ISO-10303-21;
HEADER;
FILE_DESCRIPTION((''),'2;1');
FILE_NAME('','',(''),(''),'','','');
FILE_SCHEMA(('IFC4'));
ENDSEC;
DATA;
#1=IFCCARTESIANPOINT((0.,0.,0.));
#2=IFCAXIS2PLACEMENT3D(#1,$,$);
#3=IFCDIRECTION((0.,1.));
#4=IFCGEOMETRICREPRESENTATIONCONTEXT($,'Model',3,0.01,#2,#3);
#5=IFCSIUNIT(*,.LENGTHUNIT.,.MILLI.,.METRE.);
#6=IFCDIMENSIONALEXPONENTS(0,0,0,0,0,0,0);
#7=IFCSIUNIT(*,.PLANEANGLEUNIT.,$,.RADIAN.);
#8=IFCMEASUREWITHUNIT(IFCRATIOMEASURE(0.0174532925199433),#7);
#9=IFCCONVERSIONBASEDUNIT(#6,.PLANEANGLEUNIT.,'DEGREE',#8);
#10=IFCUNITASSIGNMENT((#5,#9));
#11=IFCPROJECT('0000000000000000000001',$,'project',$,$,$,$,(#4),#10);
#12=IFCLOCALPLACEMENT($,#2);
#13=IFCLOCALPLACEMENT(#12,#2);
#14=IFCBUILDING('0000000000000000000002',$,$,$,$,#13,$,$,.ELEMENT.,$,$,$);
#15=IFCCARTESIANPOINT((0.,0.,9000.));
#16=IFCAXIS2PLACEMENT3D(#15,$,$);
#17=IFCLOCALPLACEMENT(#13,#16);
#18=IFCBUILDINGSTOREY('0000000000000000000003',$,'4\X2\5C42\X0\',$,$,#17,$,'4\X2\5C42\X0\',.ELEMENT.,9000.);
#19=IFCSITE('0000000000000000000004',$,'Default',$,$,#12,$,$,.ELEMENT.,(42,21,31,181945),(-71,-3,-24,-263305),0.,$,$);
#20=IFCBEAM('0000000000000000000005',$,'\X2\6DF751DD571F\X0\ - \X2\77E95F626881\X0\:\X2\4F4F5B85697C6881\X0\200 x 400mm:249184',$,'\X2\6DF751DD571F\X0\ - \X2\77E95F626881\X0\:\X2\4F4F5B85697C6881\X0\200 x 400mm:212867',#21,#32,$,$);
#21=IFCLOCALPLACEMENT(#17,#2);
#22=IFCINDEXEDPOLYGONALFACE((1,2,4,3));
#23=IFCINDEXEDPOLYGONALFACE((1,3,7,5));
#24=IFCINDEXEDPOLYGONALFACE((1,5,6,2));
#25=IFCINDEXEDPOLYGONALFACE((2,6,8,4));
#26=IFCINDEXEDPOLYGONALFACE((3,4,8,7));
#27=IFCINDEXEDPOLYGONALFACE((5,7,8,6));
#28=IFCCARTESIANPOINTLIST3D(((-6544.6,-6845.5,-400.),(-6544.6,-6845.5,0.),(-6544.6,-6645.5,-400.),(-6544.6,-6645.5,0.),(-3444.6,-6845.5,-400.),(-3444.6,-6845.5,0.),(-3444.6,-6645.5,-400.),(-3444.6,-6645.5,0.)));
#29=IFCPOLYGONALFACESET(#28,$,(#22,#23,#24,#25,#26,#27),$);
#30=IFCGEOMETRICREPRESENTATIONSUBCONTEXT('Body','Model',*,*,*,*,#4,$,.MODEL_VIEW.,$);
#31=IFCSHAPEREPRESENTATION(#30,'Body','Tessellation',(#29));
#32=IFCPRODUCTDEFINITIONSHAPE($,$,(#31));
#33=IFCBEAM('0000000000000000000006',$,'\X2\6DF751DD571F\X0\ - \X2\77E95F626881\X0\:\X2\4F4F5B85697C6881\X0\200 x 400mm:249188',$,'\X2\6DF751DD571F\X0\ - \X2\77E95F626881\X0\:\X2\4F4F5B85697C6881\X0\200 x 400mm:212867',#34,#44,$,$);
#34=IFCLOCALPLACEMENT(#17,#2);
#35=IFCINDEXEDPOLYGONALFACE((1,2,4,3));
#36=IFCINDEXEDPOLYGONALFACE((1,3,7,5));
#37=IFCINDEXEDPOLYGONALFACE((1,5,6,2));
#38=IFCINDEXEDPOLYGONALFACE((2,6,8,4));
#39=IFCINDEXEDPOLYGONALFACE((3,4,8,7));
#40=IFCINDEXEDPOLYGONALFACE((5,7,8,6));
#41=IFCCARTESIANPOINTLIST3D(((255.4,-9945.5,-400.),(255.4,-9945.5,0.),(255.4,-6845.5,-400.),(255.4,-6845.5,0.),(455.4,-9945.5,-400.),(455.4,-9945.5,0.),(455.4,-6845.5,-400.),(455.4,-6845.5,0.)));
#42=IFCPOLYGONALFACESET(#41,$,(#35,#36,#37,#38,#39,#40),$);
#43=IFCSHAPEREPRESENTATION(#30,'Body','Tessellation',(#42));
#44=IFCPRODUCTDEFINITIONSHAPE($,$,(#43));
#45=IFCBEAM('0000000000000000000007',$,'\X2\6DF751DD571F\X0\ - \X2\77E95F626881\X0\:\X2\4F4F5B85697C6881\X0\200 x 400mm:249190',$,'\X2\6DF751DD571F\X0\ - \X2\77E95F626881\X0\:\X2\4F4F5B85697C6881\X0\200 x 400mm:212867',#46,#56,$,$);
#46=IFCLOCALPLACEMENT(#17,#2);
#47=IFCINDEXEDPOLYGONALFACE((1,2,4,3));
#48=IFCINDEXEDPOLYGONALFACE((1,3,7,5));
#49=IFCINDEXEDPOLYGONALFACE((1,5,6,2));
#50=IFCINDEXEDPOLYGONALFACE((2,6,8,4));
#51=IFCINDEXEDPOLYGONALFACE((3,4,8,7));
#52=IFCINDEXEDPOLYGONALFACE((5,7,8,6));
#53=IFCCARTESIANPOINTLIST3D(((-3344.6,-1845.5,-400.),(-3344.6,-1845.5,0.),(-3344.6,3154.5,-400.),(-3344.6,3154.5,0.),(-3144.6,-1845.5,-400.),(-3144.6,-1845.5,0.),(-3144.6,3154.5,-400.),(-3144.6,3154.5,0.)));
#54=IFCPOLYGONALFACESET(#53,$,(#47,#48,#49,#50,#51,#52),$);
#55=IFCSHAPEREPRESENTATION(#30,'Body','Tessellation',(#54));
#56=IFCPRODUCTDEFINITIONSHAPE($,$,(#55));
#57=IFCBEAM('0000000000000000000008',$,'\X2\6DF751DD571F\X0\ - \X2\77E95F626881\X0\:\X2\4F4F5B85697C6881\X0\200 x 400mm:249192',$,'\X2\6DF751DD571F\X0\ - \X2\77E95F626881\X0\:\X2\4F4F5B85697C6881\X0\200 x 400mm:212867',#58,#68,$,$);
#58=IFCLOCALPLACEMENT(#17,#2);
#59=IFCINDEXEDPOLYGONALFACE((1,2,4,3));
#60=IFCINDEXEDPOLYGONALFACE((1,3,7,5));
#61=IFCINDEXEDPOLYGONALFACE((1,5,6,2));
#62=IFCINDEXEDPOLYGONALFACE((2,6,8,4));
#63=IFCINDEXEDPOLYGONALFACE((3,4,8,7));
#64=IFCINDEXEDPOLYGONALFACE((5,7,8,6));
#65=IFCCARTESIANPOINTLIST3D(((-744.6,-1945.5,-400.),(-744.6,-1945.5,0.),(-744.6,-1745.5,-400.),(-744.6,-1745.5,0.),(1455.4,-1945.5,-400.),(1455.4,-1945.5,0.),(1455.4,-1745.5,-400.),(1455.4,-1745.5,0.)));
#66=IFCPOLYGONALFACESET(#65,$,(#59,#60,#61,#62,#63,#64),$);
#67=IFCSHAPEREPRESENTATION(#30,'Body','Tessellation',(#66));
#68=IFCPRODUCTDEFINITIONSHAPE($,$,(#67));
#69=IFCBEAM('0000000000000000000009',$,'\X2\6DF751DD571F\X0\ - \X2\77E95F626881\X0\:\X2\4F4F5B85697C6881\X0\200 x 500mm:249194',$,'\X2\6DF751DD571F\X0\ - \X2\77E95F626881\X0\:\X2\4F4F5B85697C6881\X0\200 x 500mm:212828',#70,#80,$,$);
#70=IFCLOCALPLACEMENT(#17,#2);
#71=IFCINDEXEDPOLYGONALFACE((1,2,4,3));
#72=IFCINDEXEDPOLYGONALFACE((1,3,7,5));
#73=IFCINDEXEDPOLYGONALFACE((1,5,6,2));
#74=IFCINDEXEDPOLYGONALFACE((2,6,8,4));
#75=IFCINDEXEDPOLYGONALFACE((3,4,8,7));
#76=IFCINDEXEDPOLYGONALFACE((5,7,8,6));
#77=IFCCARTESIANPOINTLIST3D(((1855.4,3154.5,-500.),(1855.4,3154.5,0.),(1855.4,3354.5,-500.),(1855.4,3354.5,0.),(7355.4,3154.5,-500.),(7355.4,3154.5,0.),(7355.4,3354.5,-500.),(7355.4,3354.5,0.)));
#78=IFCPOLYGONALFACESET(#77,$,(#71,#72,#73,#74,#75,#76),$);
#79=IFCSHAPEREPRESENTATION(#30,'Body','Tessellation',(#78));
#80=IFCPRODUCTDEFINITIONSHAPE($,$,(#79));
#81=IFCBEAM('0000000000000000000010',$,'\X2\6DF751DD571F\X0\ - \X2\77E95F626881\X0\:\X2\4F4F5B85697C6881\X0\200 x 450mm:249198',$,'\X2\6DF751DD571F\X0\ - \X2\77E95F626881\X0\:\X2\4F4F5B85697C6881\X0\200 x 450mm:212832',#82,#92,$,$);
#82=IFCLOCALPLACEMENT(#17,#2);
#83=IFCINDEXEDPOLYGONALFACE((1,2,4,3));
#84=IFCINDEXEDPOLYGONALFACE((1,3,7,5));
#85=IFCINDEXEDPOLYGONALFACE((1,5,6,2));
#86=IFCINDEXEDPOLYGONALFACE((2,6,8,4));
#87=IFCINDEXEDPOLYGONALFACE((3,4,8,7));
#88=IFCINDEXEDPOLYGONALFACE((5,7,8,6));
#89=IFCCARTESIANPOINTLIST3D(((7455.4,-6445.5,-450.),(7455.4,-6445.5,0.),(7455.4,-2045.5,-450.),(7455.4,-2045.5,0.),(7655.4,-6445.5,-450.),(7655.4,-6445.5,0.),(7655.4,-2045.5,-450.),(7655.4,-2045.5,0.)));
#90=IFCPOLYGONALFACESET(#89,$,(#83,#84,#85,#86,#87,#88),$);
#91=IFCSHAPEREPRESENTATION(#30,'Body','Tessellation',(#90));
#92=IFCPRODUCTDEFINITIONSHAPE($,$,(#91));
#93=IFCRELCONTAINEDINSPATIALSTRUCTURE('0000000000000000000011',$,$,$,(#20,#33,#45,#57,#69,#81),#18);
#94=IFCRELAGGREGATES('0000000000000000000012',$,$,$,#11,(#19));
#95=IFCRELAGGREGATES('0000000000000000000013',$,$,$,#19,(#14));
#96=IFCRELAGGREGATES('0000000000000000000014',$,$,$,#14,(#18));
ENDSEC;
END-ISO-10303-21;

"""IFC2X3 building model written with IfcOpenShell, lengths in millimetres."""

from ifc_helpers import new_model, entity, si_unit, converted_unit, direction, frame, frame_2d, origin, origin_2d_with_axis, place, context, subcontext, project, spatial, rectangle, extrude, element, save


model = new_model("IFC2X3")

# Units and contexts
model_context = context("Model", 3, precision=0.01, world=origin(), true_north=direction((0.0, 1.0)))
body_context = subcontext(model_context, "Body", "Model", "MODEL_VIEW")
ifc_project = project(units=[si_unit("LENGTHUNIT", "METRE", prefix="MILLI"), converted_unit("PLANEANGLEUNIT", "DEGREE", entity("IfcRatioMeasure", 0.0174532925199433), si_unit("PLANEANGLEUNIT", "RADIAN"), dimensions=[0, 0, 0, 0, 0, 0, 0])], contexts=[model_context])

# Site, building, storey
site_placement = place(None, origin())
site = spatial("IfcSite", under=ifc_project, at=site_placement, Name="Default", CompositionType="ELEMENT", RefLatitude=(42, 21, 31, 181945), RefLongitude=(-71, -3, -24, -263305), RefElevation=0.0)
building_placement = place(site_placement, origin())
building = spatial("IfcBuilding", under=site, at=building_placement, CompositionType="ELEMENT")
storey_placement = place(building_placement, frame((0.0, 0.0, 9000.0)))
storey = spatial("IfcBuildingStorey", under=building, at=storey_placement, Name="4层", LongName="4层", CompositionType="ELEMENT", Elevation=9000.0)

# Beams
beam_1_placement = place(storey_placement, frame((-3244.6, -6745.5, 0.0), z_axis=(0.0, 0.0, 1.0), x_axis=(-1.0, 0.0, 0.0)))
element("IfcBeam", 1, at=beam_1_placement, inside=storey, Name="混凝土 - 矩形梁:住宅楼梁200 x 400mm:249184", ObjectType="混凝土 - 矩形梁:住宅楼梁200 x 400mm:212867", context=body_context, shape_type="SweptSolid", body=[
    extrude(rectangle(XDim=400.0, YDim=200.0, at=frame_2d((0.0, 0.0), x_axis=(1.0, 0.0))), frame((200.0, 0.0, -200.0), z_axis=(1.0, 0.0, 0.0), x_axis=(0.0, 0.0, -1.0)), (0.0, 0.0, 1.0), 3100.0),
])
beam_2_placement = place(storey_placement, frame((355.4, -10145.5, 0.0), z_axis=(0.0, 0.0, 1.0), x_axis=(0.0, 1.0, 0.0)))
element("IfcBeam", 2, at=beam_2_placement, inside=storey, Name="混凝土 - 矩形梁:住宅楼梁200 x 400mm:249188", ObjectType="混凝土 - 矩形梁:住宅楼梁200 x 400mm:212867", context=body_context, shape_type="SweptSolid", body=[
    extrude(rectangle(XDim=400.0, YDim=200.0, at=frame_2d((0.0, 0.0), x_axis=(1.0, 0.0))), frame((200.0, 0.0, -200.0), z_axis=(1.0, 0.0, 0.0), x_axis=(0.0, 0.0, -1.0)), (0.0, 0.0, 1.0), 3100.0),
])
beam_3_placement = place(storey_placement, frame((-3244.6, 3254.5, 0.0), z_axis=(0.0, 0.0, 1.0), x_axis=(0.0, -1.0, 0.0)))
element("IfcBeam", 3, at=beam_3_placement, inside=storey, Name="混凝土 - 矩形梁:住宅楼梁200 x 400mm:249190", ObjectType="混凝土 - 矩形梁:住宅楼梁200 x 400mm:212867", context=body_context, shape_type="SweptSolid", body=[
    extrude(rectangle(XDim=400.0, YDim=200.0, at=origin_2d_with_axis()), frame((100.0, 0.0, -200.0), z_axis=(1.0, 0.0, 0.0), x_axis=(0.0, 0.0, -1.0)), (0.0, 0.0, 1.0), 5000.0),
])
beam_4_placement = place(storey_placement, frame((-944.6, -1845.5, 0.0)))
element("IfcBeam", 4, at=beam_4_placement, inside=storey, Name="混凝土 - 矩形梁:住宅楼梁200 x 400mm:249192", ObjectType="混凝土 - 矩形梁:住宅楼梁200 x 400mm:212867", context=body_context, shape_type="SweptSolid", body=[
    extrude(rectangle(XDim=400.0, YDim=200.0, at=frame_2d((0.0, 0.0), x_axis=(1.0, 0.0))), frame((200.0, 0.0, -200.0), z_axis=(1.0, 0.0, 0.0), x_axis=(0.0, 0.0, -1.0)), (0.0, 0.0, 1.0), 2200.0),
])
beam_5_placement = place(storey_placement, frame((7555.4, 3254.5, 0.0), z_axis=(0.0, 0.0, 1.0), x_axis=(-1.0, 0.0, 0.0)))
element("IfcBeam", 5, at=beam_5_placement, inside=storey, Name="混凝土 - 矩形梁:住宅楼梁200 x 500mm:249194", ObjectType="混凝土 - 矩形梁:住宅楼梁200 x 500mm:212828", context=body_context, shape_type="SweptSolid", body=[
    extrude(rectangle(XDim=500.0, YDim=200.0, at=frame_2d((0.0, 0.0), x_axis=(1.0, 0.0))), frame((200.0, 0.0, -250.0), z_axis=(1.0, 0.0, 0.0), x_axis=(0.0, 0.0, -1.0)), (0.0, 0.0, 1.0), 5500.0),
])
beam_6_placement = place(storey_placement, frame((7555.4, -1945.5, 0.0), z_axis=(0.0, 0.0, 1.0), x_axis=(0.0, -1.0, 0.0)))
element("IfcBeam", 6, at=beam_6_placement, inside=storey, Name="混凝土 - 矩形梁:住宅楼梁200 x 450mm:249198", ObjectType="混凝土 - 矩形梁:住宅楼梁200 x 450mm:212832", context=body_context, shape_type="SweptSolid", body=[
    extrude(rectangle(XDim=450.0, YDim=200.0, at=frame_2d((0.0, 0.0), x_axis=(1.0, 0.0))), frame((100.0, 0.0, -225.0), z_axis=(1.0, 0.0, 0.0), x_axis=(0.0, 0.0, -1.0)), (0.0, 0.0, 1.0), 4400.0),
])

save(model, "model.ifc")
